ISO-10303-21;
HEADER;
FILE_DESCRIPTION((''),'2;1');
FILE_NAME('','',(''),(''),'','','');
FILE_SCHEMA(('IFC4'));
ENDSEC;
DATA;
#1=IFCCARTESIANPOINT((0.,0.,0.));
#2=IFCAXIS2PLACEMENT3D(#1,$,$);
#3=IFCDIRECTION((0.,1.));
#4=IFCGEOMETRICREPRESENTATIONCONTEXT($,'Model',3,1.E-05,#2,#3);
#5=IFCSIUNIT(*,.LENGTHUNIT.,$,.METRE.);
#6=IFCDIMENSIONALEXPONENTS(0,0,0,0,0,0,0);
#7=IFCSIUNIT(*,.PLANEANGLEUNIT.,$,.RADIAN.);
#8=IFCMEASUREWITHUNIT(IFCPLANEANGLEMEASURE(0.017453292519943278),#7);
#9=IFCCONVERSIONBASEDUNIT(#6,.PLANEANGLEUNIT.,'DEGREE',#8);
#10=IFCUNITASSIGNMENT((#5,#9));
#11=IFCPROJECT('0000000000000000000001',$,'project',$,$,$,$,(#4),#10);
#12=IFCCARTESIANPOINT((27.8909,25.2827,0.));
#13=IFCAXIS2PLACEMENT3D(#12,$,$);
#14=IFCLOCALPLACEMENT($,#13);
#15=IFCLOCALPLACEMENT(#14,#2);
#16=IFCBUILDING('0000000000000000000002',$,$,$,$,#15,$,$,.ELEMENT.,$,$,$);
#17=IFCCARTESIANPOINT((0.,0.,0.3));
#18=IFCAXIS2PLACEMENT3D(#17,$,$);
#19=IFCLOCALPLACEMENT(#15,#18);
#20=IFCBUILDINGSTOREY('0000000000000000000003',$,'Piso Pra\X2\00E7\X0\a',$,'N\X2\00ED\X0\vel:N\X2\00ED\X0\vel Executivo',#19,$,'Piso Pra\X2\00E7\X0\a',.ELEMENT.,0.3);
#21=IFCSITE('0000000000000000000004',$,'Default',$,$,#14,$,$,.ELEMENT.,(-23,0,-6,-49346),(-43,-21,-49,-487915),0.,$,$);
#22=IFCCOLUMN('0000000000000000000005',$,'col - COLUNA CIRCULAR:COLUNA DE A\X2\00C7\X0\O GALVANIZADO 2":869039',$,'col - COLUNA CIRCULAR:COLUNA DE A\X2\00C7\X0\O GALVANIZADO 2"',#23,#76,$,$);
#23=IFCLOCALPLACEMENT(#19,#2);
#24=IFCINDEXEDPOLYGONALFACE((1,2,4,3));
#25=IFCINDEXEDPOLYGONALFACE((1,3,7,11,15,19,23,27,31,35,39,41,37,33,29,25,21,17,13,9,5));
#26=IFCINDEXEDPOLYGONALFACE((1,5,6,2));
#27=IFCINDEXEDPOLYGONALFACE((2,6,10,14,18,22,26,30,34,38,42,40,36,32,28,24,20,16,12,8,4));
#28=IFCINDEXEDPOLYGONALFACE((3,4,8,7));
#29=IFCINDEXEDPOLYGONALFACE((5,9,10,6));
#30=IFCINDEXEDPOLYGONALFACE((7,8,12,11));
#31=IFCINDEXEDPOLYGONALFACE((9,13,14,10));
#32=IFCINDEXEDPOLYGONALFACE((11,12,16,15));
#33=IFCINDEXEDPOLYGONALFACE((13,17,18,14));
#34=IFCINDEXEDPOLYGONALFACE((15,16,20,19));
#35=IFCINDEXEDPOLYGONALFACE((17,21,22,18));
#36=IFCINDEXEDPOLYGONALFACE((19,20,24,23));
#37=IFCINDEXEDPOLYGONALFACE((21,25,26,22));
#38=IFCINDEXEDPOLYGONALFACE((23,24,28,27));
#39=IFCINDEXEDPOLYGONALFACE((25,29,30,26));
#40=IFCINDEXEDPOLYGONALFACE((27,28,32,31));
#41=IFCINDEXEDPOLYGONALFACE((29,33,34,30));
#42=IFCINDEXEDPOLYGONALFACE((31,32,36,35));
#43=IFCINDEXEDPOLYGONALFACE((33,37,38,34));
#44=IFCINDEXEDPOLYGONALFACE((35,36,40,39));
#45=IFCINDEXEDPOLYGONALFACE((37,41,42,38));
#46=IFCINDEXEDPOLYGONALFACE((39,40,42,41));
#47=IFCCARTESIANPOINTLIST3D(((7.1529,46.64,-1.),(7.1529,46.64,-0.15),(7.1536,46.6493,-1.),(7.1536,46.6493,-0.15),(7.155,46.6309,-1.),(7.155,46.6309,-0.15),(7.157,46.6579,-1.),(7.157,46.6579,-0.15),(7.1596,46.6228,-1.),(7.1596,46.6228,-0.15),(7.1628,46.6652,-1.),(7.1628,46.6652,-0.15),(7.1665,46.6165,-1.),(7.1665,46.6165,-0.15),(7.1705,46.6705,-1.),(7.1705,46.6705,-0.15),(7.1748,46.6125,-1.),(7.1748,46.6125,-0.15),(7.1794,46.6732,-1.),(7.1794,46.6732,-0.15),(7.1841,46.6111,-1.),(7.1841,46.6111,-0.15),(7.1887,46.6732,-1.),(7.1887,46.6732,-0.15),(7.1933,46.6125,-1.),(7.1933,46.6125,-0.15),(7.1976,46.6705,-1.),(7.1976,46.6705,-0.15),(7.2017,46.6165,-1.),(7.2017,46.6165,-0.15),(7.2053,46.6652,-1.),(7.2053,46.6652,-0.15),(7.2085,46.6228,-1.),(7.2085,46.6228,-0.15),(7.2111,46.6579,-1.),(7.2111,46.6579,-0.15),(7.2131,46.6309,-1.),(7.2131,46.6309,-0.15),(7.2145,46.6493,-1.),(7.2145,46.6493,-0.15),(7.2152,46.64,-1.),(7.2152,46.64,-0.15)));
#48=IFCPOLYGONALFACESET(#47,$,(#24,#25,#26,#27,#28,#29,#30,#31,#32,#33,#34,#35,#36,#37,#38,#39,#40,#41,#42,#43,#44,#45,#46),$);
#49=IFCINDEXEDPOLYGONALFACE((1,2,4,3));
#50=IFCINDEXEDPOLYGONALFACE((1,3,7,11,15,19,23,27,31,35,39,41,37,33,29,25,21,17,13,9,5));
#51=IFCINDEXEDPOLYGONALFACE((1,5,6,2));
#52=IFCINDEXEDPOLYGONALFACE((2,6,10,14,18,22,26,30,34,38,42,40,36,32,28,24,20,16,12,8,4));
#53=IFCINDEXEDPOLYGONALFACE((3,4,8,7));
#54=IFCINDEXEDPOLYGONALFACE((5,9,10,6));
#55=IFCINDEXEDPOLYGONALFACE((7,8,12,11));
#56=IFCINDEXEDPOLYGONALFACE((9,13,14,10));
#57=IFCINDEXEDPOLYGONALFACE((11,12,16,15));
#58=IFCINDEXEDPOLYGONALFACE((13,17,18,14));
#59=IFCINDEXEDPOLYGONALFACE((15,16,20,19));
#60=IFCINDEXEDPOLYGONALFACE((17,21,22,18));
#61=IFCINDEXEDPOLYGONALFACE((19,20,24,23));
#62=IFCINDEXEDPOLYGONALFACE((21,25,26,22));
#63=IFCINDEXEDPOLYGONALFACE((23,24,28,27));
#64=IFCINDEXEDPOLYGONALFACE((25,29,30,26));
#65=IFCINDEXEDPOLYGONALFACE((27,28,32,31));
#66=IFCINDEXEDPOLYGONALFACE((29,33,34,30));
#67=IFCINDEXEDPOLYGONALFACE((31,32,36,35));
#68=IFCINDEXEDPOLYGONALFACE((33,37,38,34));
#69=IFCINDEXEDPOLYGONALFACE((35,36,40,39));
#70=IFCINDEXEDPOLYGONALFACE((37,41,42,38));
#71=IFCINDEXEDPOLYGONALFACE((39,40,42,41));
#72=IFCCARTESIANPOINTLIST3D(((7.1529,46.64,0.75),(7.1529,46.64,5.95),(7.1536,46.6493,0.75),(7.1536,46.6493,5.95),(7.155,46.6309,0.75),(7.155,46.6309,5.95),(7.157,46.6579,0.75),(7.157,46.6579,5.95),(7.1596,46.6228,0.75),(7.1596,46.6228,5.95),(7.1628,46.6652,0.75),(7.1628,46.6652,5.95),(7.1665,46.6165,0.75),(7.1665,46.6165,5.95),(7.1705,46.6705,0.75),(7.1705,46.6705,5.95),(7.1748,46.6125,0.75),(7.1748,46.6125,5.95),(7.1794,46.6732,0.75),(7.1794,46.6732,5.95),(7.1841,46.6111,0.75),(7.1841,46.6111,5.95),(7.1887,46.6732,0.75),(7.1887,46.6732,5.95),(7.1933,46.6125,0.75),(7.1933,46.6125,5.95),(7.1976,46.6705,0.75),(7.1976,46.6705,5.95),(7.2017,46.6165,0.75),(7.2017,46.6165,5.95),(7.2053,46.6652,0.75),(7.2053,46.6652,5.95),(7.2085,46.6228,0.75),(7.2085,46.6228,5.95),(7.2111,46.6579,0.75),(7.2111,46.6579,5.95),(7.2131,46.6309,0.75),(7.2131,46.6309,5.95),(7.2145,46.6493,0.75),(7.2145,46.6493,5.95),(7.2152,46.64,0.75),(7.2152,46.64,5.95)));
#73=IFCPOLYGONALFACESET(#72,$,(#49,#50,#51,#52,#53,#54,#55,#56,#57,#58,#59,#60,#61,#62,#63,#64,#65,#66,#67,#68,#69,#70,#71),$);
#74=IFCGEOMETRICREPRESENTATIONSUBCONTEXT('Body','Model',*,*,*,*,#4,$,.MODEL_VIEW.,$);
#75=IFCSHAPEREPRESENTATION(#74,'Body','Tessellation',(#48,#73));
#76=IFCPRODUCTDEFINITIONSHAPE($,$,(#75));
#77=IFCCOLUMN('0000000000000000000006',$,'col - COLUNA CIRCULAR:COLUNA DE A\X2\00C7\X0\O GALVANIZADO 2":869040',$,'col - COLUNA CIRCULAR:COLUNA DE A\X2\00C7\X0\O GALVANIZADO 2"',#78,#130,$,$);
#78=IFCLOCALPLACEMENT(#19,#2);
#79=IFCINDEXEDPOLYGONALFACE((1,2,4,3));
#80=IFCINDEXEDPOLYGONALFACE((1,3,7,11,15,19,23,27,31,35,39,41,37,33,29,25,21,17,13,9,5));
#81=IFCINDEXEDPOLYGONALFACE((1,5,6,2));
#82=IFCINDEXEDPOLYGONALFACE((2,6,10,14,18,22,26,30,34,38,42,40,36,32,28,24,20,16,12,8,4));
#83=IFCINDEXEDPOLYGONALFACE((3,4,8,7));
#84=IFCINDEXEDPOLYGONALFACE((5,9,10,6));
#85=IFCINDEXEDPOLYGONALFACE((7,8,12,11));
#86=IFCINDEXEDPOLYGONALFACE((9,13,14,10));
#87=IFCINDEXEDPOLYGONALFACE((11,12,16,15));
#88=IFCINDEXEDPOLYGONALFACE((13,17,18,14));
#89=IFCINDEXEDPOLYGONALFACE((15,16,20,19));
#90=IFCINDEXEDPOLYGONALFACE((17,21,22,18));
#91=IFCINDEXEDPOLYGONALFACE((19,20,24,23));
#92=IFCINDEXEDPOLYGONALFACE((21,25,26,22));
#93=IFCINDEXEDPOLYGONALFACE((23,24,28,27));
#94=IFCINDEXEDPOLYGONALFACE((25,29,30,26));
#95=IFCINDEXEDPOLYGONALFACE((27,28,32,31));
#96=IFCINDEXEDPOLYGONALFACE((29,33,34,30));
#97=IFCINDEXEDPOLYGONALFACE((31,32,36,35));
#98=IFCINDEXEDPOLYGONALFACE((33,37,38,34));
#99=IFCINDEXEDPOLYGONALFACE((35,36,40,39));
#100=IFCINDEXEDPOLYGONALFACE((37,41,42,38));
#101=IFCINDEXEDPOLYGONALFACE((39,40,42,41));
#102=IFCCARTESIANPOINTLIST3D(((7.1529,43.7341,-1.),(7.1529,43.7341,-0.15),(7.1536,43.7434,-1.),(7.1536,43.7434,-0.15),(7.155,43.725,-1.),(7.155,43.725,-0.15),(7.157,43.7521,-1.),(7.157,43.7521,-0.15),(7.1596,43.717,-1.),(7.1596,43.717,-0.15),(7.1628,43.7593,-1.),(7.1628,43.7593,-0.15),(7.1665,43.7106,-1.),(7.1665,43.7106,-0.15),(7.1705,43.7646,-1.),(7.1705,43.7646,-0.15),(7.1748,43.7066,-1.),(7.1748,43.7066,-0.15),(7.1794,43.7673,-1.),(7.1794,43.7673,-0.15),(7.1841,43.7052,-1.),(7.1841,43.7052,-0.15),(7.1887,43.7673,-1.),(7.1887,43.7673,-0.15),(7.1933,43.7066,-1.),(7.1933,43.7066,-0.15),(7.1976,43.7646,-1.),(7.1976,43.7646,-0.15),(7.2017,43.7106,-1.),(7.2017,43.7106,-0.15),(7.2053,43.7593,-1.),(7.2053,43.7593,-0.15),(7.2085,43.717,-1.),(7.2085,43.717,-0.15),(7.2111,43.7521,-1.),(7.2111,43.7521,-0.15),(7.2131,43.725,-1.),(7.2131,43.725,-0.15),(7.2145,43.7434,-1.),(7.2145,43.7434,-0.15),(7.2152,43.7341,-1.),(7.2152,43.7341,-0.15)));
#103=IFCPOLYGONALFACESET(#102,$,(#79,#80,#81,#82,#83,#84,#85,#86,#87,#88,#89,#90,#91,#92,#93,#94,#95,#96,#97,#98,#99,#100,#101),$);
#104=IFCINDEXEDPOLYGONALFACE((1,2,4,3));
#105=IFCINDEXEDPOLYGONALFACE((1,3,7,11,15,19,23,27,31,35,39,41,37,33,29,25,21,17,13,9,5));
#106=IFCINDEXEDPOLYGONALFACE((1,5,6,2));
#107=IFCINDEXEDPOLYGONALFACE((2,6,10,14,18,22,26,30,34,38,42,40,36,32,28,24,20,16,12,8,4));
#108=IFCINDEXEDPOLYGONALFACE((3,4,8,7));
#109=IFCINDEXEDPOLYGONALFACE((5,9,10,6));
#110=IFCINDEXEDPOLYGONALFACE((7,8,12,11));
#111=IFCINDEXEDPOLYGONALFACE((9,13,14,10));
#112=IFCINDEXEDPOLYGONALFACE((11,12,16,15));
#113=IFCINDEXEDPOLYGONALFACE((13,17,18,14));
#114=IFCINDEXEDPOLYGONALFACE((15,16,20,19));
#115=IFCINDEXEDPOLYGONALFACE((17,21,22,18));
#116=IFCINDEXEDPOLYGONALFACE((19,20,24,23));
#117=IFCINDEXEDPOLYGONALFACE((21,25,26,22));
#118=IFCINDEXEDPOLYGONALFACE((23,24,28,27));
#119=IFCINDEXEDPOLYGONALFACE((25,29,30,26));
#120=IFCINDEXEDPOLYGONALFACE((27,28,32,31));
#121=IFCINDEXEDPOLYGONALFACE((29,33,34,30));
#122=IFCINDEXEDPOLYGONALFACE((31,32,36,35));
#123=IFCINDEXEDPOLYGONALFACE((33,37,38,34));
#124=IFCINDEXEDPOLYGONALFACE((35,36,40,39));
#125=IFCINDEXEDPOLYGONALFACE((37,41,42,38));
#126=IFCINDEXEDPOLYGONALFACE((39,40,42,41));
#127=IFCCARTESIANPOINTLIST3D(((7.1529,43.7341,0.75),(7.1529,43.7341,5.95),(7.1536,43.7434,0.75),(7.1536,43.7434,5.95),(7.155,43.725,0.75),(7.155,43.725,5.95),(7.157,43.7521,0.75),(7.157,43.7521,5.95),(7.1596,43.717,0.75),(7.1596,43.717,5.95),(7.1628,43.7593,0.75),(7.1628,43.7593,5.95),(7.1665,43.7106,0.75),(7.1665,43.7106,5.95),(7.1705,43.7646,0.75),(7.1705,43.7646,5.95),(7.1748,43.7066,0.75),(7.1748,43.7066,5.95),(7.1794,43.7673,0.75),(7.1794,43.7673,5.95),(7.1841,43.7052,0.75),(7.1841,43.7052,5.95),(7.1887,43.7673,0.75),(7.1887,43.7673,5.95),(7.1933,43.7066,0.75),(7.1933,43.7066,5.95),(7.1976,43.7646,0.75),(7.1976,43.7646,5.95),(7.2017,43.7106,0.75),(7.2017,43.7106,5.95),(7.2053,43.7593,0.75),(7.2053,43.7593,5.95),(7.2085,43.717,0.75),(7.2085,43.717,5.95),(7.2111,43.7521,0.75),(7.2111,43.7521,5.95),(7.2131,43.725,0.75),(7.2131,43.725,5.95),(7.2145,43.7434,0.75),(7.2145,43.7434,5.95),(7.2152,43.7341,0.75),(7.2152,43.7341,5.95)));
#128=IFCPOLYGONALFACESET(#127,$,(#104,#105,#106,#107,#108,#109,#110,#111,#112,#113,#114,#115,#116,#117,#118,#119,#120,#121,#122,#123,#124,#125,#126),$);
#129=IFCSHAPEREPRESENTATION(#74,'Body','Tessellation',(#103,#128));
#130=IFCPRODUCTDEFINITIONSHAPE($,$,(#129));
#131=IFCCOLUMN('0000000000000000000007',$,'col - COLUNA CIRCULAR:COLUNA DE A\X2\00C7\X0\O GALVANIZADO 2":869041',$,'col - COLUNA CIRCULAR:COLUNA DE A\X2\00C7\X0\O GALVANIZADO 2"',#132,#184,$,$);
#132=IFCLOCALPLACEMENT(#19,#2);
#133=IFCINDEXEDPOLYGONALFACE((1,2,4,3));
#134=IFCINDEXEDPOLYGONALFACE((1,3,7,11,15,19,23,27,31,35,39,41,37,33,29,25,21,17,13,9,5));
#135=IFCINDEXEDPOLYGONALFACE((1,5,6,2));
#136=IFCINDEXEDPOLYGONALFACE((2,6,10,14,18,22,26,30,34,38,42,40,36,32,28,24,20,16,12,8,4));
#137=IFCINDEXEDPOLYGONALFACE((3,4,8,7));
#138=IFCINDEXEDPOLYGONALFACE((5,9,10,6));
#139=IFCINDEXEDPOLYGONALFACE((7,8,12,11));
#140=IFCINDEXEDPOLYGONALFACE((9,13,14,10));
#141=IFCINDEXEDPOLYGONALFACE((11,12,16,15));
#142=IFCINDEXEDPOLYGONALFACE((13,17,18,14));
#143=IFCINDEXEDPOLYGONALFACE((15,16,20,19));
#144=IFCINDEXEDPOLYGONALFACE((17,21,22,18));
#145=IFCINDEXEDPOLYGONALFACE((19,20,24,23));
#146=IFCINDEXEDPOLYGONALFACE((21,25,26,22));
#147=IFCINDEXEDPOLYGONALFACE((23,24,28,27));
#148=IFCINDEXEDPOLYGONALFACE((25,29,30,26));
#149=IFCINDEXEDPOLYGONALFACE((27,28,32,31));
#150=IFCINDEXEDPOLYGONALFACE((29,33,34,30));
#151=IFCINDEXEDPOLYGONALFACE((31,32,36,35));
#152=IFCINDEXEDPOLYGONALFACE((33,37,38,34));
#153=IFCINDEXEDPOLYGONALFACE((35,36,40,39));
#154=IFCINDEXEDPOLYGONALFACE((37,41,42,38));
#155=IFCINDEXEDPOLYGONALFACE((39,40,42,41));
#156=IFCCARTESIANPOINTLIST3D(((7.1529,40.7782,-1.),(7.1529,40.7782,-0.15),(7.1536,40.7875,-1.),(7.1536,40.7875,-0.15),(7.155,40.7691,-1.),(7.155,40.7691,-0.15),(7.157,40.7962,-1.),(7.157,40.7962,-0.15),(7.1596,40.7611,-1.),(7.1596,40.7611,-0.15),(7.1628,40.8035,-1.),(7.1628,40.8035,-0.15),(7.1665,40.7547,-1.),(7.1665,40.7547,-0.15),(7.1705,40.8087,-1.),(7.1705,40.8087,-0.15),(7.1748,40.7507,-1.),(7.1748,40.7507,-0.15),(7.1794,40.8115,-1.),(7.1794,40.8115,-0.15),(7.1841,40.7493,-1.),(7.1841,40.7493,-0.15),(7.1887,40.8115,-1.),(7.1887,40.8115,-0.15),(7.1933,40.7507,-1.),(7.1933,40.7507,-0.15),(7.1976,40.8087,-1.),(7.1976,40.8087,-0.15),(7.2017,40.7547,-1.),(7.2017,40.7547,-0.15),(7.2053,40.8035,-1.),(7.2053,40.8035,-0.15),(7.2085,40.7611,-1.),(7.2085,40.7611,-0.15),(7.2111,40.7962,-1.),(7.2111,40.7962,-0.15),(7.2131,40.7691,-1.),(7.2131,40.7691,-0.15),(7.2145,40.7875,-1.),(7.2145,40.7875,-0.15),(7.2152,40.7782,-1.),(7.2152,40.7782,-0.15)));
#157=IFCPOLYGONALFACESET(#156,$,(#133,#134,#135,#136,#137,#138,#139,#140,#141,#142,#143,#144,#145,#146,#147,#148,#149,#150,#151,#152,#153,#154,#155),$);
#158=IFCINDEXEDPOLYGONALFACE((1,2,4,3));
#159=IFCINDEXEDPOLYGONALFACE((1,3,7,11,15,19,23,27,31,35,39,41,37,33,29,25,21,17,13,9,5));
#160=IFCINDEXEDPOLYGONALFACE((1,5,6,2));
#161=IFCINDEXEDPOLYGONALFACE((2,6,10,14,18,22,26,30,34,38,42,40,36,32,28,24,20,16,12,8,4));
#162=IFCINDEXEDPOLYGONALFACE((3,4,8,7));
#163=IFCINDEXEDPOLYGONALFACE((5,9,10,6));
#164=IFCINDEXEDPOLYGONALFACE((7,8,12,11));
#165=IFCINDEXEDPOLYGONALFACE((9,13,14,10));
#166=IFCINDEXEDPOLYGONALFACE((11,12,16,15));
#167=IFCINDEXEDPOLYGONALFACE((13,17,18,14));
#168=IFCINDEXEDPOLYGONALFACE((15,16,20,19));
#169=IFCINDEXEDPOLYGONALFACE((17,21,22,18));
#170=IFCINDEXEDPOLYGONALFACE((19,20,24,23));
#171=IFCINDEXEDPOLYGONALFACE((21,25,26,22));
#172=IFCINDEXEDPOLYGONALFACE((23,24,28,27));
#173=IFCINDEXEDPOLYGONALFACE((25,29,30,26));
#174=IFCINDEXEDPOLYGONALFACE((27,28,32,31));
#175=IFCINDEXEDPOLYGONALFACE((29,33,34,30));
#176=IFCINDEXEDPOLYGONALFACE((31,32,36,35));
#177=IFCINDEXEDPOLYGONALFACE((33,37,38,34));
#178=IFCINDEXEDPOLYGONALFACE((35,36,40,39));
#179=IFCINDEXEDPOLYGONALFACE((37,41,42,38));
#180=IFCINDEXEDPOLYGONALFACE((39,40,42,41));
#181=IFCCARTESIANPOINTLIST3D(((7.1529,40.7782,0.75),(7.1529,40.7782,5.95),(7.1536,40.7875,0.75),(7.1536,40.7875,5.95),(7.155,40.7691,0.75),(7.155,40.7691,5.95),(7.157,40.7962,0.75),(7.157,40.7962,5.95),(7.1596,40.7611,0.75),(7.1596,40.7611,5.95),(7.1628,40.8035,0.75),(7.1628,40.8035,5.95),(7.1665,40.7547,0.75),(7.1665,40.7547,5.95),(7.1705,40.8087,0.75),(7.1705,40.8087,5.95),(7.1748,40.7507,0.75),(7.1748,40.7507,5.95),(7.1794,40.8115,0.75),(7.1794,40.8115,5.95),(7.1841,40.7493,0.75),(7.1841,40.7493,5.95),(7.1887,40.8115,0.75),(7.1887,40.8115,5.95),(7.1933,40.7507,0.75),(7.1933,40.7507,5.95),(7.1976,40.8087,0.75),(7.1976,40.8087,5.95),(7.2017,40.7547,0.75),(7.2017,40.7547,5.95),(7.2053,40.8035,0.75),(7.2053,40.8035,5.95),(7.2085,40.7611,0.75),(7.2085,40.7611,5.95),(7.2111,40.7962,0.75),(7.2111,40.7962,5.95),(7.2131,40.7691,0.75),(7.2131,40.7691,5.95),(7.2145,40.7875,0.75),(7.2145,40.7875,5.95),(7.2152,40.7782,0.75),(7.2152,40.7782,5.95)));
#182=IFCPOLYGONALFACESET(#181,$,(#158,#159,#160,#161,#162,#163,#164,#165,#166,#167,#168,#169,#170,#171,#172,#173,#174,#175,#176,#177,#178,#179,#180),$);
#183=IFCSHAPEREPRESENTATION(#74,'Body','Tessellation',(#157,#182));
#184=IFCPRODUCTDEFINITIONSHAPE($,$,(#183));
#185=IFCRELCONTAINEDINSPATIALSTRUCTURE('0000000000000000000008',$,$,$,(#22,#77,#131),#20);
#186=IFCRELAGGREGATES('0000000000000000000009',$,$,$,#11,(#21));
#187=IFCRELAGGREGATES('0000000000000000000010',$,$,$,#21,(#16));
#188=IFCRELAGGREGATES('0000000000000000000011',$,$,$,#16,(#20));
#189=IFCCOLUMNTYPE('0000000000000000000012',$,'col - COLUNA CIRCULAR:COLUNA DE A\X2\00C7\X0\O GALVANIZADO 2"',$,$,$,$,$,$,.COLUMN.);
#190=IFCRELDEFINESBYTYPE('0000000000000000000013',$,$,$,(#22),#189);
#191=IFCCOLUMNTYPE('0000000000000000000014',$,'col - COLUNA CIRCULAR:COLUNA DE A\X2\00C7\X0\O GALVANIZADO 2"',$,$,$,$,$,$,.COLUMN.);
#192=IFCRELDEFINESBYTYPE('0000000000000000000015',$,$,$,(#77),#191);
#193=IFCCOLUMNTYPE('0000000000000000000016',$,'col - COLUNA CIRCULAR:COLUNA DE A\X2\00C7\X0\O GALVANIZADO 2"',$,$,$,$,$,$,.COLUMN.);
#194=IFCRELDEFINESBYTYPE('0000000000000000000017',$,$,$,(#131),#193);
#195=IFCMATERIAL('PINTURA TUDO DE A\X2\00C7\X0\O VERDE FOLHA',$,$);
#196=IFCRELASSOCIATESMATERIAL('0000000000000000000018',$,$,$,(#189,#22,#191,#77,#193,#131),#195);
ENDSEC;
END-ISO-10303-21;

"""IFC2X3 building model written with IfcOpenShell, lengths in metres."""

from ifc_helpers import new_model, entity, si_unit, converted_unit, direction, frame, origin, origin_2d_with_axis, place, context, subcontext, project, spatial, circle, extrude, source, transform, mapped, material, type_object, type_shapes, element, save


model = new_model("IFC2X3")

# Units and contexts
model_context = context("Model", 3, precision=1e-05, world=origin(), true_north=direction((0.0, 1.0)))
body_context = subcontext(model_context, "Body", "Model", "MODEL_VIEW")
ifc_project = project(units=[si_unit("LENGTHUNIT", "METRE"), converted_unit("PLANEANGLEUNIT", "DEGREE", entity("IfcPlaneAngleMeasure", 0.017453292519943278), si_unit("PLANEANGLEUNIT", "RADIAN"), dimensions=[0, 0, 0, 0, 0, 0, 0])], contexts=[model_context])

# Site, building, storey
site_placement = place(None, frame((27.8909, 25.2827, 0.0)))
site = spatial("IfcSite", under=ifc_project, at=site_placement, Name="Default", CompositionType="ELEMENT", RefLatitude=(-23, 0, -6, -49346), RefLongitude=(-43, -21, -49, -487915), RefElevation=0.0)
building_placement = place(site_placement, origin())
building = spatial("IfcBuilding", under=site, at=building_placement, CompositionType="ELEMENT")
storey_placement = place(building_placement, frame((0.0, 0.0, 0.3)))
storey = spatial("IfcBuildingStorey", under=building, at=storey_placement, Name="Piso Praça", ObjectType="Nível:Nível Executivo", LongName="Piso Praça", CompositionType="ELEMENT", Elevation=0.3)

# Columns
ifc_material = material(Name="PINTURA TUDO DE AÇO VERDE FOLHA")
column_type_1 = type_object("IfcColumnType", Name="col - COLUNA CIRCULAR:COLUNA DE AÇO GALVANIZADO 2\"", PredefinedType="COLUMN", material=ifc_material)
shared_shape_1 = source(origin(), body_context, "Body", "SweptSolid", [
    extrude(circle(Radius=0.0312, at=origin_2d_with_axis()), frame((7.1841, 46.6423, -0.7), z_axis=(0.0, 0.0, 1.0), x_axis=(0.0, -1.0, 0.0)), (0.0, 0.0, 1.0), 0.85),
    extrude(circle(Radius=0.0312, at=origin_2d_with_axis()), frame((7.1841, 46.6423, 1.05), z_axis=(0.0, 0.0, 1.0), x_axis=(0.0, -1.0, 0.0)), (0.0, 0.0, 1.0), 5.2),
])
type_shapes(column_type_1, [shared_shape_1])
column_1_placement = place(storey_placement, frame((0.0, 0.0, -0.3)))
element("IfcColumn", 1, at=column_1_placement, inside=storey, type_object=column_type_1, material=ifc_material, Name="col - COLUNA CIRCULAR:COLUNA DE AÇO GALVANIZADO 2\":869039", ObjectType="col - COLUNA CIRCULAR:COLUNA DE AÇO GALVANIZADO 2\"", context=body_context, shape_type="MappedRepresentation", body=[
    mapped(shared_shape_1, transform((0.0, 0.0, 0.0), scale=1.0)),
])
column_type_2 = type_object("IfcColumnType", Name="col - COLUNA CIRCULAR:COLUNA DE AÇO GALVANIZADO 2\"", PredefinedType="COLUMN", material=ifc_material)
shared_shape_2 = source(origin(), body_context, "Body", "SweptSolid", [
    extrude(circle(Radius=0.0312, at=origin_2d_with_axis()), frame((7.1841, 43.7364, -0.7), z_axis=(0.0, 0.0, 1.0), x_axis=(0.0, -1.0, 0.0)), (0.0, 0.0, 1.0), 0.85),
    extrude(circle(Radius=0.0312, at=origin_2d_with_axis()), frame((7.1841, 43.7364, 1.05), z_axis=(0.0, 0.0, 1.0), x_axis=(0.0, -1.0, 0.0)), (0.0, 0.0, 1.0), 5.2),
])
type_shapes(column_type_2, [shared_shape_2])
column_2_placement = place(storey_placement, frame((0.0, 0.0, -0.3)))
element("IfcColumn", 2, at=column_2_placement, inside=storey, type_object=column_type_2, material=ifc_material, Name="col - COLUNA CIRCULAR:COLUNA DE AÇO GALVANIZADO 2\":869040", ObjectType="col - COLUNA CIRCULAR:COLUNA DE AÇO GALVANIZADO 2\"", context=body_context, shape_type="MappedRepresentation", body=[
    mapped(shared_shape_2, transform((0.0, 0.0, 0.0), scale=1.0)),
])
column_type_3 = type_object("IfcColumnType", Name="col - COLUNA CIRCULAR:COLUNA DE AÇO GALVANIZADO 2\"", PredefinedType="COLUMN", material=ifc_material)
shared_shape_3 = source(origin(), body_context, "Body", "SweptSolid", [
    extrude(circle(Radius=0.0312, at=origin_2d_with_axis()), frame((7.1841, 40.7806, -0.7), z_axis=(0.0, 0.0, 1.0), x_axis=(0.0, -1.0, 0.0)), (0.0, 0.0, 1.0), 0.85),
    extrude(circle(Radius=0.0312, at=origin_2d_with_axis()), frame((7.1841, 40.7806, 1.05), z_axis=(0.0, 0.0, 1.0), x_axis=(0.0, -1.0, 0.0)), (0.0, 0.0, 1.0), 5.2),
])
type_shapes(column_type_3, [shared_shape_3])
column_3_placement = place(storey_placement, frame((0.0, 0.0, -0.3)))
element("IfcColumn", 3, at=column_3_placement, inside=storey, type_object=column_type_3, material=ifc_material, Name="col - COLUNA CIRCULAR:COLUNA DE AÇO GALVANIZADO 2\":869041", ObjectType="col - COLUNA CIRCULAR:COLUNA DE AÇO GALVANIZADO 2\"", context=body_context, shape_type="MappedRepresentation", body=[
    mapped(shared_shape_3, transform((0.0, 0.0, 0.0), scale=1.0)),
])

save(model, "model.ifc")
